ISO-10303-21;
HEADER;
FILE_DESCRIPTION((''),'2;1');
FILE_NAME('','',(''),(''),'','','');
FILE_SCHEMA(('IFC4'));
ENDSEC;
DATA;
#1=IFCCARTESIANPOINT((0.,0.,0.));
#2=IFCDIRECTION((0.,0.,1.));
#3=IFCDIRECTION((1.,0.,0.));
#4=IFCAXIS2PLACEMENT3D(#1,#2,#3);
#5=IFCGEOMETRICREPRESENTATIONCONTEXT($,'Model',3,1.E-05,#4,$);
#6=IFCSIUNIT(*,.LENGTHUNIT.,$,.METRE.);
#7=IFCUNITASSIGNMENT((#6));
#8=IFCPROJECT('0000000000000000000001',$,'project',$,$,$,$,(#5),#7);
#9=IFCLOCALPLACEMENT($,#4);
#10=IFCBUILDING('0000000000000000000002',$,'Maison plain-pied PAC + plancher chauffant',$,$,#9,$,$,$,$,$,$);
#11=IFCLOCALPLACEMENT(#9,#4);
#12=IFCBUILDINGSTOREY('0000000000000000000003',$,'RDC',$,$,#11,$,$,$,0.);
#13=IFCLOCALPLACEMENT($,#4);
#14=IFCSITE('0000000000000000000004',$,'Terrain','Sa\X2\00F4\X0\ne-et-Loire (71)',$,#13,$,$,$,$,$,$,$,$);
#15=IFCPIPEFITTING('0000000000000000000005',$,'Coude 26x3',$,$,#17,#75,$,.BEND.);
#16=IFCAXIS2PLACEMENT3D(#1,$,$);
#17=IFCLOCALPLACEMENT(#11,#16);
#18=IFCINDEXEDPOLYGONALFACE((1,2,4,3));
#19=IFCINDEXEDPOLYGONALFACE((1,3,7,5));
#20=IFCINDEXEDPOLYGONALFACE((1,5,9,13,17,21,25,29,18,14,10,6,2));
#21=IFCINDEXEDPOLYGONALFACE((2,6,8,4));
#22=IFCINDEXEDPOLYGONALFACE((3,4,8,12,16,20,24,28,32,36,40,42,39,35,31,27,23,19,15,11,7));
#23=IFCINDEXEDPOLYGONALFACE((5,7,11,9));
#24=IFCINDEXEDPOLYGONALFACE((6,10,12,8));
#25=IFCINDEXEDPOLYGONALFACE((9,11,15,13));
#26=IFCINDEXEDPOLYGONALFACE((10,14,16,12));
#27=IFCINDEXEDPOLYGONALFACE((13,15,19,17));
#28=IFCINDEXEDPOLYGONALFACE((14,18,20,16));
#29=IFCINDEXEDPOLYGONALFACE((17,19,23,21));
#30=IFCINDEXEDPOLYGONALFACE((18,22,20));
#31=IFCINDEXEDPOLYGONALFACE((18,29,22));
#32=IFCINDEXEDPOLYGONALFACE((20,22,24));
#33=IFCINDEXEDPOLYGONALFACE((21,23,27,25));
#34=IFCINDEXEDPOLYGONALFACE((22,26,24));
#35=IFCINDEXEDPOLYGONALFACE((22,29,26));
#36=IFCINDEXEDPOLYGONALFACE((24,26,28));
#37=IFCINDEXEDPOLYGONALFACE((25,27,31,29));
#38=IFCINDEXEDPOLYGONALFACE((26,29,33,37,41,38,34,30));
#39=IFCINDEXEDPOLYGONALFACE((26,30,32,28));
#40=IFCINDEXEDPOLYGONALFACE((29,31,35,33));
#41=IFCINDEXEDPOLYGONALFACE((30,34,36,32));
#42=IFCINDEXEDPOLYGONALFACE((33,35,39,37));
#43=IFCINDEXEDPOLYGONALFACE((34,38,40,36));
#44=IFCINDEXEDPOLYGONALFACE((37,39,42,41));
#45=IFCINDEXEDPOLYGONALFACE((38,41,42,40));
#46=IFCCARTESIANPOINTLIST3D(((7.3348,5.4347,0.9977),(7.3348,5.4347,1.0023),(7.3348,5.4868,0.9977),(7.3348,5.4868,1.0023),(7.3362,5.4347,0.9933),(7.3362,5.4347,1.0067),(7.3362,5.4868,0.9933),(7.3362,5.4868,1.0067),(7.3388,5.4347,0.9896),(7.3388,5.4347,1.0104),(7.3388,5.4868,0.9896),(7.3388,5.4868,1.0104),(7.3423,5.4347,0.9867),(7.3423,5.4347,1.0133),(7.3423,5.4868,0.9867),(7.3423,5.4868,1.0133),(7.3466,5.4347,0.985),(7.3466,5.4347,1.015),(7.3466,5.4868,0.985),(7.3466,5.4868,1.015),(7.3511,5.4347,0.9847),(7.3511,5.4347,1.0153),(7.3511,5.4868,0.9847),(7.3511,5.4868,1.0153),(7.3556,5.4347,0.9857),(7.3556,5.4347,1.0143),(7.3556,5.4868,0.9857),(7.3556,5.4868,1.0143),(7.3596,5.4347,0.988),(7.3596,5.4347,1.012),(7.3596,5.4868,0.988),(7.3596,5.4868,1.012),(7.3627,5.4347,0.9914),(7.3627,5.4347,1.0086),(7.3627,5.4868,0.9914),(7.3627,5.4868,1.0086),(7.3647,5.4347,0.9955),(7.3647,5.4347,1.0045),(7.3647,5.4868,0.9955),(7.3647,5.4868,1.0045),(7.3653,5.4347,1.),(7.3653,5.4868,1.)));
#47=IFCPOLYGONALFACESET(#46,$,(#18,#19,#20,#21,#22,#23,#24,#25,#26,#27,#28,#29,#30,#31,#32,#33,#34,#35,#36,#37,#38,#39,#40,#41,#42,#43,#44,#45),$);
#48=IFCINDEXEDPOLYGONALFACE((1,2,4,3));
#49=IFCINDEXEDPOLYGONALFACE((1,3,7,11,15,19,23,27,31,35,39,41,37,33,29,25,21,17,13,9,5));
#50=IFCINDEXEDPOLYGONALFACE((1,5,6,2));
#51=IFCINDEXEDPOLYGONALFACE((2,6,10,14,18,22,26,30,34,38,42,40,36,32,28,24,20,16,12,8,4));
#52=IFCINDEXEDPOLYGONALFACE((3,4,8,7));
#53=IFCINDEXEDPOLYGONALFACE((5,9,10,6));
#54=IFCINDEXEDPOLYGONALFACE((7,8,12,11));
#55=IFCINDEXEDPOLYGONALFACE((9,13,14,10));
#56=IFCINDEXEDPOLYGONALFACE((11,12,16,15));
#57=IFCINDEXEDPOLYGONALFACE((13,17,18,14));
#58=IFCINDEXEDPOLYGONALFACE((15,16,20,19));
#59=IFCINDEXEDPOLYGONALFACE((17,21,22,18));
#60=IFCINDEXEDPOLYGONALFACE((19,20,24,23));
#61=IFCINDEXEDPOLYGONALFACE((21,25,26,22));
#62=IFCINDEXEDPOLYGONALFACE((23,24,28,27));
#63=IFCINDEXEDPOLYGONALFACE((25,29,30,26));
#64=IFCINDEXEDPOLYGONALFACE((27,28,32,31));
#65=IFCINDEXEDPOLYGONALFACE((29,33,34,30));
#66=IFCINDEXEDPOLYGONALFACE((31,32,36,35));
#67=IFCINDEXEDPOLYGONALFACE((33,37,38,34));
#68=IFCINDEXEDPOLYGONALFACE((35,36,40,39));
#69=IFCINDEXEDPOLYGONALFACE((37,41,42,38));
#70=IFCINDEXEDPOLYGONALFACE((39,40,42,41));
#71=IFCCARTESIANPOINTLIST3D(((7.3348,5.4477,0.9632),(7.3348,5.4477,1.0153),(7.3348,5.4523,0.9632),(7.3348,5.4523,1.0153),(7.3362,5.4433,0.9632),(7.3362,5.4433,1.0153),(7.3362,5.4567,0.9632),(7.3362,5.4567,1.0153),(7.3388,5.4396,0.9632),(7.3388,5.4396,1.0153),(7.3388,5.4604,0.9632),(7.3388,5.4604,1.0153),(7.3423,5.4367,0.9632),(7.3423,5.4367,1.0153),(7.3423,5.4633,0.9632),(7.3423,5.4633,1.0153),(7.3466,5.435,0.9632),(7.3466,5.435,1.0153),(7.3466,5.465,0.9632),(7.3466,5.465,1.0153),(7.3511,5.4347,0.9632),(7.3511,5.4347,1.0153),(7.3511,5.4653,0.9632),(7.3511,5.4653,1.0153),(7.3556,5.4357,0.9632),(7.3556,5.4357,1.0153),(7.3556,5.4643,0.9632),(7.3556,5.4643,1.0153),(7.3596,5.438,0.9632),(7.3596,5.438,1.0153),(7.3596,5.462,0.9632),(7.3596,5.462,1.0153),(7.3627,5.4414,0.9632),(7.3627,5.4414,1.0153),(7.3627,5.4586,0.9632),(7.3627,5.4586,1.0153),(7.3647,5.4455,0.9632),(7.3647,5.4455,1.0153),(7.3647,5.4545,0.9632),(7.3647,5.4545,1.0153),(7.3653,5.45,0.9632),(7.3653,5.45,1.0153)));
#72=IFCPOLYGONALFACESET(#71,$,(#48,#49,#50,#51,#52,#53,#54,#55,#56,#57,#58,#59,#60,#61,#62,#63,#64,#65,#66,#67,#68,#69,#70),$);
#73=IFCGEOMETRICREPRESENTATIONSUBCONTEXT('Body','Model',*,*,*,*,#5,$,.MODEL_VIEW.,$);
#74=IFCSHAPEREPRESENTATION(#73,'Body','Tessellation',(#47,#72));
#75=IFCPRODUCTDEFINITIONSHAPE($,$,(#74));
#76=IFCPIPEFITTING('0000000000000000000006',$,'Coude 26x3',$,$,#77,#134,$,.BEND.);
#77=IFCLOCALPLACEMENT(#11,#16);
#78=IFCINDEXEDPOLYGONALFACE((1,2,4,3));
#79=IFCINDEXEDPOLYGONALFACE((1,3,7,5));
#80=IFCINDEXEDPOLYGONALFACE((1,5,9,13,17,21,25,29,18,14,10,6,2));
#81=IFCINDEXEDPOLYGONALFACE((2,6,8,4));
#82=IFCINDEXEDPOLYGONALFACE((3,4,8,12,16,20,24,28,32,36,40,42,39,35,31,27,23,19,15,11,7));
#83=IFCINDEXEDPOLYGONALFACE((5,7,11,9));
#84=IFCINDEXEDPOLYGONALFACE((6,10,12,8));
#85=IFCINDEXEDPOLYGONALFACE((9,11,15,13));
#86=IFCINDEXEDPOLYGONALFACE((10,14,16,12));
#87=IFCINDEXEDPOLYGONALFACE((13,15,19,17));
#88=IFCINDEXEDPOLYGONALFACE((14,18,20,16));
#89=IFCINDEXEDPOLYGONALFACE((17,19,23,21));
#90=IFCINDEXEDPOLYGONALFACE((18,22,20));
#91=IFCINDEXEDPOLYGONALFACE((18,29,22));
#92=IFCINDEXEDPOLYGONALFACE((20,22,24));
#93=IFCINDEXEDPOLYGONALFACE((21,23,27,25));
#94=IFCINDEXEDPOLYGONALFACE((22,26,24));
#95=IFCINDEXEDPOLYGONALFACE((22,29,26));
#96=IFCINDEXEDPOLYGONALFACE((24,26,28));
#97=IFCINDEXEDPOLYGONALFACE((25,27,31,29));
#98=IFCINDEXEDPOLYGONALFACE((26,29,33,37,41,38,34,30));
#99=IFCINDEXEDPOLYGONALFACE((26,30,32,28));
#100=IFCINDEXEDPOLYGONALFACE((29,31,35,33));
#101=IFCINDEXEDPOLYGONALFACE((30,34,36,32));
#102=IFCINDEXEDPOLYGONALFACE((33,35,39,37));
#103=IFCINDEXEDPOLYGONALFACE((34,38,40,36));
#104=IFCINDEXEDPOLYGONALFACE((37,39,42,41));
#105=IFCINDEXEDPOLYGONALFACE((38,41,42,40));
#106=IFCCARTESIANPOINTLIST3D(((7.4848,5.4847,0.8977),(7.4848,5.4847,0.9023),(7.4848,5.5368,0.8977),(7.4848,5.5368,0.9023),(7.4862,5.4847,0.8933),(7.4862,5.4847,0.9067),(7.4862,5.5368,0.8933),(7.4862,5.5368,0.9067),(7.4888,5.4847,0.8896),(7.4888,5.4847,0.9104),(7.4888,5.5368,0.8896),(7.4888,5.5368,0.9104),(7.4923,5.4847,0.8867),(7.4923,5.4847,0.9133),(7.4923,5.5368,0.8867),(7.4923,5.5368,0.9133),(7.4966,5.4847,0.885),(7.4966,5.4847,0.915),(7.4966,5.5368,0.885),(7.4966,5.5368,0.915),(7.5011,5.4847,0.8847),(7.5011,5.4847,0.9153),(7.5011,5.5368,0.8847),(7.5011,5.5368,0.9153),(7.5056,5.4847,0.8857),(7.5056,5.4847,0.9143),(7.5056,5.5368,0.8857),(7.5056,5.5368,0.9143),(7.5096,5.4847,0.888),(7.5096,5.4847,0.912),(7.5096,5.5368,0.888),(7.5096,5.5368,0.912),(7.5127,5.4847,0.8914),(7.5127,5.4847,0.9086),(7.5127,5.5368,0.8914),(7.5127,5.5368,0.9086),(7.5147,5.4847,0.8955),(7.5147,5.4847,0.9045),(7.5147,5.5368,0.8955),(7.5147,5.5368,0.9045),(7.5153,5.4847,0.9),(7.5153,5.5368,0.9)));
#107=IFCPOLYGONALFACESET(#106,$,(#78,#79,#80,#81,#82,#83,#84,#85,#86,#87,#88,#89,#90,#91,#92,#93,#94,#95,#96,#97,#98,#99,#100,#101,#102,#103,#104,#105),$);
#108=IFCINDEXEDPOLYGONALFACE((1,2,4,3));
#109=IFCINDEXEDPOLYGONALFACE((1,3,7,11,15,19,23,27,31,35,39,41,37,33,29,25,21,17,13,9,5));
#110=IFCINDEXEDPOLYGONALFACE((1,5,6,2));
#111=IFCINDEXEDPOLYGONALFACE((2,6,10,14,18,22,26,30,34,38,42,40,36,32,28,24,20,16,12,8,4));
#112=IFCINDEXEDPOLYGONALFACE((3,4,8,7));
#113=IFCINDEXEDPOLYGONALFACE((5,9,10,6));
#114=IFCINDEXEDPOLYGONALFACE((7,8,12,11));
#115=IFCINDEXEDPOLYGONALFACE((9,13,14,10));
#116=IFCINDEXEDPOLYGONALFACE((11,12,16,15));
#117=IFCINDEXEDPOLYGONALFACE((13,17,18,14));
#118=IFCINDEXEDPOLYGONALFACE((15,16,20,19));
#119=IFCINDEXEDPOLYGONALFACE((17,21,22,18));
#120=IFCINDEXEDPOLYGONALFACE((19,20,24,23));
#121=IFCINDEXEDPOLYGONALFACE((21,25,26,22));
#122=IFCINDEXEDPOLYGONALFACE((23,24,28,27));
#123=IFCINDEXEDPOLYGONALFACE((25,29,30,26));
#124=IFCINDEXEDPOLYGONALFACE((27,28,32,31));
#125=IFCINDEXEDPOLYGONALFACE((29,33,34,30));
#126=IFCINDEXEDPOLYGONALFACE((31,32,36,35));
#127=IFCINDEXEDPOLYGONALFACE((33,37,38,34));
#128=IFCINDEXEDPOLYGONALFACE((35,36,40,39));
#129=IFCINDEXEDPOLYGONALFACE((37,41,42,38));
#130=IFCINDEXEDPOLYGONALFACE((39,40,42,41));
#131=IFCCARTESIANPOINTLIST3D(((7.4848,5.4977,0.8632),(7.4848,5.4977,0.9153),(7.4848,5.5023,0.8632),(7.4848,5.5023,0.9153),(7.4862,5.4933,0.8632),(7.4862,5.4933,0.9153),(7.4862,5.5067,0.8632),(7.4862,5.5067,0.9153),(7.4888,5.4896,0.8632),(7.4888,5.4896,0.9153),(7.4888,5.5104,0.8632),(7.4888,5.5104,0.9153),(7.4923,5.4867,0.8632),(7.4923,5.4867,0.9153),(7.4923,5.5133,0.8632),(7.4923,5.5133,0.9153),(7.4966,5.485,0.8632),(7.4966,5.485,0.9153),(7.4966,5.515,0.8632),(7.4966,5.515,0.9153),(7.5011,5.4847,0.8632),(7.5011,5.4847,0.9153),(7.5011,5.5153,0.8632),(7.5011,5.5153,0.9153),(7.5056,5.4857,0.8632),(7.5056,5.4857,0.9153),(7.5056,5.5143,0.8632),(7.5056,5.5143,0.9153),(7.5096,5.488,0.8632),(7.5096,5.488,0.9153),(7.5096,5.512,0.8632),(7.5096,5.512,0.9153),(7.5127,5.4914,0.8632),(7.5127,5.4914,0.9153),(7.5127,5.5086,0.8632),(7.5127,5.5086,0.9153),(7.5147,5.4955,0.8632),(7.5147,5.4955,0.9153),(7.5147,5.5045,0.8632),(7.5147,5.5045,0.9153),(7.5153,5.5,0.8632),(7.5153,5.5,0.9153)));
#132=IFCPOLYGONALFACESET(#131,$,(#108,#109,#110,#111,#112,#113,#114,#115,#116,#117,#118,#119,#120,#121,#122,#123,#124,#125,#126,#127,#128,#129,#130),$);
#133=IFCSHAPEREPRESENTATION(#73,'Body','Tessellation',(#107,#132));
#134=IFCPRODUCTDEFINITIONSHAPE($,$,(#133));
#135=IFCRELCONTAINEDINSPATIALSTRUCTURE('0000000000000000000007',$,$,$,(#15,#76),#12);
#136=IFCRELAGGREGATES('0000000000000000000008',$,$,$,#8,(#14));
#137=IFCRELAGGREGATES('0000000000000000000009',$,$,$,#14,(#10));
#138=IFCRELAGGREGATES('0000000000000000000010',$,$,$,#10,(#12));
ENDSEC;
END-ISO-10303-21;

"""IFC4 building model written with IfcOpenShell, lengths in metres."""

from ifc_helpers import new_model, si_unit, frame, origin_with_axes, place, context, subcontext, project, spatial, circle, extrude, element, save


model = new_model("IFC4")

# Units and contexts
model_context = context("Model", 3, precision=1e-05, world=origin_with_axes())
body_context = subcontext(model_context, "Body", "Model", "MODEL_VIEW")
ifc_project = project(units=[si_unit("LENGTHUNIT", "METRE")], contexts=[model_context])

# Site, building, storey
site_placement = place(None, origin_with_axes())
site = spatial("IfcSite", under=ifc_project, at=site_placement, Name="Terrain", Description="Saône-et-Loire (71)")
building_placement = place(None, origin_with_axes())
building = spatial("IfcBuilding", under=site, at=building_placement, Name="Maison plain-pied PAC + plancher chauffant")
storey_placement = place(building_placement, origin_with_axes())
storey = spatial("IfcBuildingStorey", under=building, at=storey_placement, Name="RDC", Elevation=0.0)

# Pipe fittings
for number, where, z_axis, x_axis, name in (
    (1, (7.35, 5.45, 1.0), (0.0, 0.0, 1.0), (1.0, 0.0, 0.0), "Coude 26x3"),
    (2, (7.5, 5.5, 0.9), (0.0, 0.0, 1.0), (1.0, 0.0, 0.0), "Coude 26x3"),
):
    element("IfcPipeFitting", number, at=place(storey_placement, frame(where, z_axis=z_axis, x_axis=x_axis)), inside=storey, Name=name, PredefinedType="BEND", context=body_context, shape_type="SweptSolid", body=[
        extrude(circle(Radius=0.0153), frame((0.0, -0.0153, 0.0), z_axis=(0.0, 1.0, 0.0), x_axis=(1.0, 0.0, 0.0)), (0.0, 0.0, 1.0), 0.0522),
        extrude(circle(Radius=0.0153), frame((0.0, 0.0, 0.0153), z_axis=(0.0, 0.0, -1.0), x_axis=(1.0, 0.0, 0.0)), (0.0, 0.0, 1.0), 0.0522),
    ])

save(model, "model.ifc")
